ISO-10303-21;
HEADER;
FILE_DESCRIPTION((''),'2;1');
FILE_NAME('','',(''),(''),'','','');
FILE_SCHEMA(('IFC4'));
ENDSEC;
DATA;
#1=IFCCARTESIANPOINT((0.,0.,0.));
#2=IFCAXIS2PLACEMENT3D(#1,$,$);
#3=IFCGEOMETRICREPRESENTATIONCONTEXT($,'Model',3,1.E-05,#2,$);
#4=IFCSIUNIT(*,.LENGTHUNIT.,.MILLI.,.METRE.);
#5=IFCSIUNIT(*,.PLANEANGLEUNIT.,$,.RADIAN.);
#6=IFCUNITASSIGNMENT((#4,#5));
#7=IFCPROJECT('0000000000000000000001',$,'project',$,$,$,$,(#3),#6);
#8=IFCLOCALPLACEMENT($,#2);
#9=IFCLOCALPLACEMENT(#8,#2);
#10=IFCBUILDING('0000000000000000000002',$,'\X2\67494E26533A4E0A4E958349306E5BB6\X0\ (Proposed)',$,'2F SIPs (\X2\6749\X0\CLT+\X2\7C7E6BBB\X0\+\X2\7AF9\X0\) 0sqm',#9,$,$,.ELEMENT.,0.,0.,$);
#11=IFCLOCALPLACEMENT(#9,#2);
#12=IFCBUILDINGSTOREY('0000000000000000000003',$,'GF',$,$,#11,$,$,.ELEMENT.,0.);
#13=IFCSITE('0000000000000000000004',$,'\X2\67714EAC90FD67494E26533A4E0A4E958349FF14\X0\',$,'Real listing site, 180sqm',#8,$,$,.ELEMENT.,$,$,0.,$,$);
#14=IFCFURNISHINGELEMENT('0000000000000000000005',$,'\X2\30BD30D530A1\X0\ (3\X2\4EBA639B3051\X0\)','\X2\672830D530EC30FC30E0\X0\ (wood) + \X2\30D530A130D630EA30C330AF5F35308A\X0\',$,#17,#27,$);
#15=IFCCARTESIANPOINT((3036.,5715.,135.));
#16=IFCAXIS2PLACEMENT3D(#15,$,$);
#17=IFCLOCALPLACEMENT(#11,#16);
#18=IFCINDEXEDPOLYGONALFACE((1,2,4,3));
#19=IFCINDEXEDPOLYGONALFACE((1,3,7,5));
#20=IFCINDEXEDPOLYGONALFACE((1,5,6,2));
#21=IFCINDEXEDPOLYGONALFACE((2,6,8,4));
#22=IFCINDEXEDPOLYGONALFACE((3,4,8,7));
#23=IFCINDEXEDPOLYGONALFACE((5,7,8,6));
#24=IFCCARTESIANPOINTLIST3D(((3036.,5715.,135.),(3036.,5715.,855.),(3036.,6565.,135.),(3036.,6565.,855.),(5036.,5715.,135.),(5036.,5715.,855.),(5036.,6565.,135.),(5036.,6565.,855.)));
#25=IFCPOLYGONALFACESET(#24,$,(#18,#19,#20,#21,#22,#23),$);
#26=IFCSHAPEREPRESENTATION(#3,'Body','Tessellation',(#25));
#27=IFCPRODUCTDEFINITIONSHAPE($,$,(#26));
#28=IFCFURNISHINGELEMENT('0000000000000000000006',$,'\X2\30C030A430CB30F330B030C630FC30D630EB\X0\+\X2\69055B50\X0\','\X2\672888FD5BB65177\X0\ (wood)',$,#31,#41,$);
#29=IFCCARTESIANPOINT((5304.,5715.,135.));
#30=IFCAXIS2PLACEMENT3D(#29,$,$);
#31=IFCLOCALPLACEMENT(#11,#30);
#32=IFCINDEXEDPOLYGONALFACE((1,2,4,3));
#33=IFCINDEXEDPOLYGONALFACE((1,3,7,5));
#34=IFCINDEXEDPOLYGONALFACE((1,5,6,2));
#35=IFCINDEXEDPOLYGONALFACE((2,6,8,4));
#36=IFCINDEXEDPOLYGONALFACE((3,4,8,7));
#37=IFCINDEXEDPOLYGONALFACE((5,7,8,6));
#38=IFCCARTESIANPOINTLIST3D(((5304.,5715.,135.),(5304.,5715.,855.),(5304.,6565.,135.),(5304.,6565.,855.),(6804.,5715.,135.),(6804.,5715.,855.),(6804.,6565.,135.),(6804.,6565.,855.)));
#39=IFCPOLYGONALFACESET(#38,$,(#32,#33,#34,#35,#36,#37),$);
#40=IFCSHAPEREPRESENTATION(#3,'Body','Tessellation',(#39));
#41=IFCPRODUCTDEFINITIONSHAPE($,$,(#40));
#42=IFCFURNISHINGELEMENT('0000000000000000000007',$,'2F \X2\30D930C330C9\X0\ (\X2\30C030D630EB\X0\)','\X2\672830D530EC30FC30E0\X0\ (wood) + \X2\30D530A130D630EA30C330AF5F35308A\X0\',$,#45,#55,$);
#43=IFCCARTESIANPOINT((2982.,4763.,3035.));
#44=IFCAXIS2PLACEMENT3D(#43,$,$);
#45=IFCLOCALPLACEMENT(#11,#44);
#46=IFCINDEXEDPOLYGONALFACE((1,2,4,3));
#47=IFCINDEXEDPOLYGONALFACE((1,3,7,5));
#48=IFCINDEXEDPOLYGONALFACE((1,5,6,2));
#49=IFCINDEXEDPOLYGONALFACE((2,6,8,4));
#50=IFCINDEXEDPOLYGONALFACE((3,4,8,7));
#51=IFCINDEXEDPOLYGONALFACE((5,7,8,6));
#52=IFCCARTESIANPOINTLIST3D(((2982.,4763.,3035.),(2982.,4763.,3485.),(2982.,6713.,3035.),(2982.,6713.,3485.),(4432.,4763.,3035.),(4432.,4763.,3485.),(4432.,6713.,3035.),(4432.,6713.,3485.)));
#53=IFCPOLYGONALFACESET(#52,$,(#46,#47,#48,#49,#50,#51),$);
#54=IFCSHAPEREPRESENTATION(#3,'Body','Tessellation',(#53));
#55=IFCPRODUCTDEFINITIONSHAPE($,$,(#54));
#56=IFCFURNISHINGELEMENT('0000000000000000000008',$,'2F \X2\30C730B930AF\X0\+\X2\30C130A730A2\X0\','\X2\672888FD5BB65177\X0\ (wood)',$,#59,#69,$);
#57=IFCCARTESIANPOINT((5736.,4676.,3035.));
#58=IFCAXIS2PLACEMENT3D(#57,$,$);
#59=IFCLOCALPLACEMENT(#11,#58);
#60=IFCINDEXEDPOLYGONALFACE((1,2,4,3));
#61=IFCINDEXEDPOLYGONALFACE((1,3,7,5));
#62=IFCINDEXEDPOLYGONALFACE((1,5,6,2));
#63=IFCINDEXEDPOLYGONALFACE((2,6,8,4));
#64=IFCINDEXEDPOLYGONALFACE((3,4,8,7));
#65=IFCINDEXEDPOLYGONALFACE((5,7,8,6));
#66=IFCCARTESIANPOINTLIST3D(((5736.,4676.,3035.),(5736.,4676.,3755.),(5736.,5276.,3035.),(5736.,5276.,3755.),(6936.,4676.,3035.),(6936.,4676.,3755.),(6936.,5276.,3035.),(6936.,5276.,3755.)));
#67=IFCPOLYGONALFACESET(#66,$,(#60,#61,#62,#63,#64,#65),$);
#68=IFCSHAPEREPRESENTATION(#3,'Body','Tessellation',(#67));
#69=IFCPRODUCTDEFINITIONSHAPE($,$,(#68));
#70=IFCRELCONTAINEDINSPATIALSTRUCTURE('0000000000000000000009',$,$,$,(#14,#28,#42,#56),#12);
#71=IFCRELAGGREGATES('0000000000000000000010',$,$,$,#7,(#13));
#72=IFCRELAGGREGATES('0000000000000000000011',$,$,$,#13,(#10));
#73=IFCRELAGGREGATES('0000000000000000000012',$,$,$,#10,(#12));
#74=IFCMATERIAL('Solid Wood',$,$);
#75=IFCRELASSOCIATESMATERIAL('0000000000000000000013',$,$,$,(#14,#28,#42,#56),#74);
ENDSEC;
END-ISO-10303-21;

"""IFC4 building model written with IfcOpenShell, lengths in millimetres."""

from ifc_helpers import new_model, si_unit, frame, frame_2d, origin, place, context, project, spatial, rectangle, extrude, material, element, save


model = new_model("IFC4")

# Units and contexts
model_context = context("Model", 3, precision=1e-05, world=origin())
ifc_project = project(units=[si_unit("LENGTHUNIT", "METRE", prefix="MILLI"), si_unit("PLANEANGLEUNIT", "RADIAN")], contexts=[model_context])

# Site, building, storey
site_placement = place(None, origin())
site = spatial("IfcSite", under=ifc_project, at=site_placement, Name="東京都杉並区上井草４", ObjectType="Real listing site, 180sqm", CompositionType="ELEMENT", RefElevation=0.0)
building_placement = place(site_placement, origin())
building = spatial("IfcBuilding", under=site, at=building_placement, Name="杉並区上井草の家 (Proposed)", ObjectType="2F SIPs (杉CLT+籾殻+竹) 0sqm", CompositionType="ELEMENT", ElevationOfRefHeight=0.0, ElevationOfTerrain=0.0)
storey_placement = place(building_placement, origin())
storey = spatial("IfcBuildingStorey", under=building, at=storey_placement, Name="GF", CompositionType="ELEMENT", Elevation=0.0)

# Shared definitions
ifc_material_1 = material(Name="Solid Wood")

# Furnishing elements
furnishing_1_placement = place(storey_placement, frame((3036.0, 5715.0, 135.0)))
element("IfcFurnishingElement", 1, at=furnishing_1_placement, inside=storey, material=ifc_material_1, Name="ソファ (3人掛け)", Description="木フレーム (wood) + ファブリック張り", context=model_context, shape_type="SweptSolid", body=[
    extrude(rectangle(XDim=2000.0, YDim=850.0, at=frame_2d((1000.0, 425.0))), frame((3036.0, 5715.0, 135.0)), (0.0, 0.0, 1.0), 720.0),
])
furnishing_2_placement = place(storey_placement, frame((5304.0, 5715.0, 135.0)))
element("IfcFurnishingElement", 2, at=furnishing_2_placement, inside=storey, material=ifc_material_1, Name="ダイニングテーブル+椅子", Description="木製家具 (wood)", context=model_context, shape_type="SweptSolid", body=[
    extrude(rectangle(XDim=1500.0, YDim=850.0, at=frame_2d((750.0, 425.0))), frame((5304.0, 5715.0, 135.0)), (0.0, 0.0, 1.0), 720.0),
])
furnishing_3_placement = place(storey_placement, frame((2982.0, 4763.0, 3035.0)))
element("IfcFurnishingElement", 3, at=furnishing_3_placement, inside=storey, material=ifc_material_1, Name="2F ベッド (ダブル)", Description="木フレーム (wood) + ファブリック張り", context=model_context, shape_type="SweptSolid", body=[
    extrude(rectangle(XDim=1450.0, YDim=1950.0, at=frame_2d((725.0, 975.0))), frame((2982.0, 4763.0, 3035.0)), (0.0, 0.0, 1.0), 450.0),
])
furnishing_4_placement = place(storey_placement, frame((5736.0, 4676.0, 3035.0)))
element("IfcFurnishingElement", 4, at=furnishing_4_placement, inside=storey, material=ifc_material_1, Name="2F デスク+チェア", Description="木製家具 (wood)", context=model_context, shape_type="SweptSolid", body=[
    extrude(rectangle(XDim=1200.0, YDim=600.0, at=frame_2d((600.0, 300.0))), frame((5736.0, 4676.0, 3035.0)), (0.0, 0.0, 1.0), 720.0),
])

save(model, "model.ifc")
